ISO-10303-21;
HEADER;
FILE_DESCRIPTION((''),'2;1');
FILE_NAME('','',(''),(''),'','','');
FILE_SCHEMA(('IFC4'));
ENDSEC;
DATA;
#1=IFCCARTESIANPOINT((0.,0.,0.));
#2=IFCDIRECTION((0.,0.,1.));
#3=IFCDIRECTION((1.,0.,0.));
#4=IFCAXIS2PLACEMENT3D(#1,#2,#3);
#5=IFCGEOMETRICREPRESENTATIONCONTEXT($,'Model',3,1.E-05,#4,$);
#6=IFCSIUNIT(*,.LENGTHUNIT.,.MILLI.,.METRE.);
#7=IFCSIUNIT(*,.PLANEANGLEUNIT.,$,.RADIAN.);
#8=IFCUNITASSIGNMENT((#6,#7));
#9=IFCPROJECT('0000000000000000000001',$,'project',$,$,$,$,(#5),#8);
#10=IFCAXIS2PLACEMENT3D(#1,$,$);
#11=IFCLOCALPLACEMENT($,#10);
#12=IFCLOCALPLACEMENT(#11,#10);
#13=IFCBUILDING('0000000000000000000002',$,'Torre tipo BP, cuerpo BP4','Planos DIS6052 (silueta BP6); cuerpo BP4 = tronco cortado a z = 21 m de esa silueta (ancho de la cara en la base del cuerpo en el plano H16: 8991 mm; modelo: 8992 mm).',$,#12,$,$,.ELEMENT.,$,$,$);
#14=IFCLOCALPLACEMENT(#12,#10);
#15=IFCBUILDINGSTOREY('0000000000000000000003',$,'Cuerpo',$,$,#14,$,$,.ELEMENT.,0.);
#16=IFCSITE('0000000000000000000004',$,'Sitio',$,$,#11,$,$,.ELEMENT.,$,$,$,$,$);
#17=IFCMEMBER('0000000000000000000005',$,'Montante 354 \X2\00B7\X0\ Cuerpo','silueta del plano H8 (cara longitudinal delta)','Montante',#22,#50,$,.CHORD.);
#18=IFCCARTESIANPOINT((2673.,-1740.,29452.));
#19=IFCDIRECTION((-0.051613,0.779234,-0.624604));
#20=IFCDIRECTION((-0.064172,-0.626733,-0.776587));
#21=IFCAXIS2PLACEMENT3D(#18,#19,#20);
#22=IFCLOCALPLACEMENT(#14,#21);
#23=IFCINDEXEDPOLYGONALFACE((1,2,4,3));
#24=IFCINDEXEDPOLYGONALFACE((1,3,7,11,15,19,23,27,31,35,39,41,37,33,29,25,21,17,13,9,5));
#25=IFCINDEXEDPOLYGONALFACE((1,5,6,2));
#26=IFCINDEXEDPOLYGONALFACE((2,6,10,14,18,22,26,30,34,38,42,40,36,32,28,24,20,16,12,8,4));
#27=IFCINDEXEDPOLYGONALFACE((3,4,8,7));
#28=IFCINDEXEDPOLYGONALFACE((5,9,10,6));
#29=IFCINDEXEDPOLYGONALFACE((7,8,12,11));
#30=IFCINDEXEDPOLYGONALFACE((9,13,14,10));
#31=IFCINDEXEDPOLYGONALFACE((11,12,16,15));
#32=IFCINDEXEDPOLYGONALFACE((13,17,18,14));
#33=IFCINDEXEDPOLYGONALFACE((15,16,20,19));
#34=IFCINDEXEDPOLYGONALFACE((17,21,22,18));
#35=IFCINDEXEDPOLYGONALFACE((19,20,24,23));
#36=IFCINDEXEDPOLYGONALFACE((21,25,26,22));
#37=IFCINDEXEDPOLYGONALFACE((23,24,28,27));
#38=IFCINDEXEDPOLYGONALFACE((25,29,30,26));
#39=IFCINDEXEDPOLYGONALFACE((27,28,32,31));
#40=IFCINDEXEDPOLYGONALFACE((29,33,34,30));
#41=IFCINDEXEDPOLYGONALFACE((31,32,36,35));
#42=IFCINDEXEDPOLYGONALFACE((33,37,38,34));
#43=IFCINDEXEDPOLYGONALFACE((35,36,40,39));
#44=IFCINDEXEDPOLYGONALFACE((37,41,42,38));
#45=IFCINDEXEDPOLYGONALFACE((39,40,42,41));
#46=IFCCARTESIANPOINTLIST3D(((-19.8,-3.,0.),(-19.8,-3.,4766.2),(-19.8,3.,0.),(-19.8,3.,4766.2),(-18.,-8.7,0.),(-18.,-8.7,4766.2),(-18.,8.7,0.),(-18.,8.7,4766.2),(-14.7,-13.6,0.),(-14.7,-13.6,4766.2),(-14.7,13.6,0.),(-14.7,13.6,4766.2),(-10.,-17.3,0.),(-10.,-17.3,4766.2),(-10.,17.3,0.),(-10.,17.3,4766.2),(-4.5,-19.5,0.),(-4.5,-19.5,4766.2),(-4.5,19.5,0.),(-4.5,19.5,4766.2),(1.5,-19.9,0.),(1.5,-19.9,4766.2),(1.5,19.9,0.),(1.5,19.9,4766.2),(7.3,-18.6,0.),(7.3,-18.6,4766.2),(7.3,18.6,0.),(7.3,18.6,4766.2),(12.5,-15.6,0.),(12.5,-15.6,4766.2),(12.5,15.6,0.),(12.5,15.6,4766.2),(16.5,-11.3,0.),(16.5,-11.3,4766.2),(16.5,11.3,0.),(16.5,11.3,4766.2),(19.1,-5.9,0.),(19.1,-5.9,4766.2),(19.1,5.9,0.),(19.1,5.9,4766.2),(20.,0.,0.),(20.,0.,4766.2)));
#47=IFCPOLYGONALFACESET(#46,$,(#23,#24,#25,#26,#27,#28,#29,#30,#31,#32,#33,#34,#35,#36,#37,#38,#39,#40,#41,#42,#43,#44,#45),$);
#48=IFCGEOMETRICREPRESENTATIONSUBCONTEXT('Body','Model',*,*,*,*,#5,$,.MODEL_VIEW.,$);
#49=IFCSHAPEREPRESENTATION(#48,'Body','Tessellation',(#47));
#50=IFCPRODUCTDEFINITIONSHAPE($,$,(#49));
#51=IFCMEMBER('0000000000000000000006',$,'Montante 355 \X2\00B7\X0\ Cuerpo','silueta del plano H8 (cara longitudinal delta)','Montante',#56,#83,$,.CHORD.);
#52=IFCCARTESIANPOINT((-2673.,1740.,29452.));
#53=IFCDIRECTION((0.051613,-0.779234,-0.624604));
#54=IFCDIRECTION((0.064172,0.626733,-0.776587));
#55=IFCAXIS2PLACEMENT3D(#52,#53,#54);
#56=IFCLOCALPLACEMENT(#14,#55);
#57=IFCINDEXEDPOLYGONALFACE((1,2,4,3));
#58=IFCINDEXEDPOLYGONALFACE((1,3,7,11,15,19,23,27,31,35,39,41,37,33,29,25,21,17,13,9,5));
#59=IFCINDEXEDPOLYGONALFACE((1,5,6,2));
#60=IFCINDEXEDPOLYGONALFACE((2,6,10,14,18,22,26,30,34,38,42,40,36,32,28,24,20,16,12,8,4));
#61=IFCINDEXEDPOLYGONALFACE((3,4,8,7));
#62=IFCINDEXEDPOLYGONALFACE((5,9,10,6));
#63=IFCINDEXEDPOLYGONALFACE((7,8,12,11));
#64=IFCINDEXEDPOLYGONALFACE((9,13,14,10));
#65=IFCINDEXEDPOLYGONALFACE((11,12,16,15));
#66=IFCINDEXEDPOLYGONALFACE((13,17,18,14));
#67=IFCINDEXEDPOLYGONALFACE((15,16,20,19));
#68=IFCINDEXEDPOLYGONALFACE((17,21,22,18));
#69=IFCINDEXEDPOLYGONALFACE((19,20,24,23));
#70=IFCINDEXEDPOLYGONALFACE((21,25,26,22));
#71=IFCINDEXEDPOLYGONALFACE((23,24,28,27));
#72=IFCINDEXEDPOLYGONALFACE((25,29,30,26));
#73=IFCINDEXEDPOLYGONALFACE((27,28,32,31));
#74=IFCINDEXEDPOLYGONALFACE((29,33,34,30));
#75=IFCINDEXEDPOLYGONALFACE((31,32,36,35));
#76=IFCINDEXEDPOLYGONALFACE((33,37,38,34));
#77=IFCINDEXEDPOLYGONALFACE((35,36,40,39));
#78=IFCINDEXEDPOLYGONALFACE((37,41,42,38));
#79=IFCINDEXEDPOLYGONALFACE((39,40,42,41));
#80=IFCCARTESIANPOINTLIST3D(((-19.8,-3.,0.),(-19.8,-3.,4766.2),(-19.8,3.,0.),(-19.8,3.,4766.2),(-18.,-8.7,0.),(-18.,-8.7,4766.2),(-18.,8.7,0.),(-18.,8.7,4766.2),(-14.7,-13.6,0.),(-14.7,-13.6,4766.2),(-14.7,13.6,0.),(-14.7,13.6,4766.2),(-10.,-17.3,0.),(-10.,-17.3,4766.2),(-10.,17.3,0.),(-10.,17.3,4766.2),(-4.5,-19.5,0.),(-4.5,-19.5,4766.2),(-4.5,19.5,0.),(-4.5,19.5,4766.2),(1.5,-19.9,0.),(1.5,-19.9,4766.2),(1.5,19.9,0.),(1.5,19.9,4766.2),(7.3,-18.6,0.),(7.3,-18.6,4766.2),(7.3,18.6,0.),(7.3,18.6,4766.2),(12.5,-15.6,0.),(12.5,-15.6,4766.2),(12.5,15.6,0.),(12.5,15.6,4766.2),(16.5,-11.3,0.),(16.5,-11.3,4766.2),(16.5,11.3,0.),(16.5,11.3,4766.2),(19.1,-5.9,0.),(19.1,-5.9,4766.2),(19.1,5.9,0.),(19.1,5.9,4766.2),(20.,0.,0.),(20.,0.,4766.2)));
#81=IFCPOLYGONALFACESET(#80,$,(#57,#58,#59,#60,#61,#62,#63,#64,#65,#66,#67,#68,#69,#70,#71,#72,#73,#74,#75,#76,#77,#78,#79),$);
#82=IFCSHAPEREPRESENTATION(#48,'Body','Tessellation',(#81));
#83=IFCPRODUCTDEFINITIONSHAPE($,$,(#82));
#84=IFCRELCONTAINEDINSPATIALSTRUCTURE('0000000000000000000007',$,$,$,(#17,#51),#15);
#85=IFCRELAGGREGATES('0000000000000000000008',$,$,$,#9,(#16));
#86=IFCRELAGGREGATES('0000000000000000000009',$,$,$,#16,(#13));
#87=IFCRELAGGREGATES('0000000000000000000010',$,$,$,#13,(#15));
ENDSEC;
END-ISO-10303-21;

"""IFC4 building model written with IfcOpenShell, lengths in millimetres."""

from ifc_helpers import new_model, si_unit, frame, origin, origin_with_axes, place, context, subcontext, project, spatial, circle, extrude, element, save


model = new_model("IFC4")

# Units and contexts
model_context = context("Model", 3, precision=1e-05, world=origin_with_axes())
body_context = subcontext(model_context, "Body", "Model", "MODEL_VIEW")
ifc_project = project(units=[si_unit("LENGTHUNIT", "METRE", prefix="MILLI"), si_unit("PLANEANGLEUNIT", "RADIAN")], contexts=[model_context])

# Site, building, storey
site_placement = place(None, origin())
site = spatial("IfcSite", under=ifc_project, at=site_placement, Name="Sitio", CompositionType="ELEMENT")
building_placement = place(site_placement, origin())
building = spatial("IfcBuilding", under=site, at=building_placement, Name="Torre tipo BP, cuerpo BP4", Description="Planos DIS6052 (silueta BP6); cuerpo BP4 = tronco cortado a z = 21 m de esa silueta (ancho de la cara en la base del cuerpo en el plano H16: 8991 mm; modelo: 8992 mm).", CompositionType="ELEMENT")
storey_placement = place(building_placement, origin())
storey = spatial("IfcBuildingStorey", under=building, at=storey_placement, Name="Cuerpo", CompositionType="ELEMENT", Elevation=0.0)

# Members
for number, where, z_axis, x_axis, name in (
    (1, (2673.0, -1740.0, 29452.0), (-0.051613, 0.779234, -0.624604), (-0.064172, -0.626733, -0.776587), "Montante 354 · Cuerpo"),
    (2, (-2673.0, 1740.0, 29452.0), (0.051613, -0.779234, -0.624604), (0.064172, 0.626733, -0.776587), "Montante 355 · Cuerpo"),
):
    element("IfcMember", number, at=place(storey_placement, frame(where, z_axis=z_axis, x_axis=x_axis)), inside=storey, Name=name, Description="silueta del plano H8 (cara longitudinal delta)", ObjectType="Montante", PredefinedType="CHORD", context=body_context, shape_type="SweptSolid", body=[
        extrude(circle(Radius=20.0), None, (0.0, 0.0, 1.0), 4766.2),
    ])

save(model, "model.ifc")
